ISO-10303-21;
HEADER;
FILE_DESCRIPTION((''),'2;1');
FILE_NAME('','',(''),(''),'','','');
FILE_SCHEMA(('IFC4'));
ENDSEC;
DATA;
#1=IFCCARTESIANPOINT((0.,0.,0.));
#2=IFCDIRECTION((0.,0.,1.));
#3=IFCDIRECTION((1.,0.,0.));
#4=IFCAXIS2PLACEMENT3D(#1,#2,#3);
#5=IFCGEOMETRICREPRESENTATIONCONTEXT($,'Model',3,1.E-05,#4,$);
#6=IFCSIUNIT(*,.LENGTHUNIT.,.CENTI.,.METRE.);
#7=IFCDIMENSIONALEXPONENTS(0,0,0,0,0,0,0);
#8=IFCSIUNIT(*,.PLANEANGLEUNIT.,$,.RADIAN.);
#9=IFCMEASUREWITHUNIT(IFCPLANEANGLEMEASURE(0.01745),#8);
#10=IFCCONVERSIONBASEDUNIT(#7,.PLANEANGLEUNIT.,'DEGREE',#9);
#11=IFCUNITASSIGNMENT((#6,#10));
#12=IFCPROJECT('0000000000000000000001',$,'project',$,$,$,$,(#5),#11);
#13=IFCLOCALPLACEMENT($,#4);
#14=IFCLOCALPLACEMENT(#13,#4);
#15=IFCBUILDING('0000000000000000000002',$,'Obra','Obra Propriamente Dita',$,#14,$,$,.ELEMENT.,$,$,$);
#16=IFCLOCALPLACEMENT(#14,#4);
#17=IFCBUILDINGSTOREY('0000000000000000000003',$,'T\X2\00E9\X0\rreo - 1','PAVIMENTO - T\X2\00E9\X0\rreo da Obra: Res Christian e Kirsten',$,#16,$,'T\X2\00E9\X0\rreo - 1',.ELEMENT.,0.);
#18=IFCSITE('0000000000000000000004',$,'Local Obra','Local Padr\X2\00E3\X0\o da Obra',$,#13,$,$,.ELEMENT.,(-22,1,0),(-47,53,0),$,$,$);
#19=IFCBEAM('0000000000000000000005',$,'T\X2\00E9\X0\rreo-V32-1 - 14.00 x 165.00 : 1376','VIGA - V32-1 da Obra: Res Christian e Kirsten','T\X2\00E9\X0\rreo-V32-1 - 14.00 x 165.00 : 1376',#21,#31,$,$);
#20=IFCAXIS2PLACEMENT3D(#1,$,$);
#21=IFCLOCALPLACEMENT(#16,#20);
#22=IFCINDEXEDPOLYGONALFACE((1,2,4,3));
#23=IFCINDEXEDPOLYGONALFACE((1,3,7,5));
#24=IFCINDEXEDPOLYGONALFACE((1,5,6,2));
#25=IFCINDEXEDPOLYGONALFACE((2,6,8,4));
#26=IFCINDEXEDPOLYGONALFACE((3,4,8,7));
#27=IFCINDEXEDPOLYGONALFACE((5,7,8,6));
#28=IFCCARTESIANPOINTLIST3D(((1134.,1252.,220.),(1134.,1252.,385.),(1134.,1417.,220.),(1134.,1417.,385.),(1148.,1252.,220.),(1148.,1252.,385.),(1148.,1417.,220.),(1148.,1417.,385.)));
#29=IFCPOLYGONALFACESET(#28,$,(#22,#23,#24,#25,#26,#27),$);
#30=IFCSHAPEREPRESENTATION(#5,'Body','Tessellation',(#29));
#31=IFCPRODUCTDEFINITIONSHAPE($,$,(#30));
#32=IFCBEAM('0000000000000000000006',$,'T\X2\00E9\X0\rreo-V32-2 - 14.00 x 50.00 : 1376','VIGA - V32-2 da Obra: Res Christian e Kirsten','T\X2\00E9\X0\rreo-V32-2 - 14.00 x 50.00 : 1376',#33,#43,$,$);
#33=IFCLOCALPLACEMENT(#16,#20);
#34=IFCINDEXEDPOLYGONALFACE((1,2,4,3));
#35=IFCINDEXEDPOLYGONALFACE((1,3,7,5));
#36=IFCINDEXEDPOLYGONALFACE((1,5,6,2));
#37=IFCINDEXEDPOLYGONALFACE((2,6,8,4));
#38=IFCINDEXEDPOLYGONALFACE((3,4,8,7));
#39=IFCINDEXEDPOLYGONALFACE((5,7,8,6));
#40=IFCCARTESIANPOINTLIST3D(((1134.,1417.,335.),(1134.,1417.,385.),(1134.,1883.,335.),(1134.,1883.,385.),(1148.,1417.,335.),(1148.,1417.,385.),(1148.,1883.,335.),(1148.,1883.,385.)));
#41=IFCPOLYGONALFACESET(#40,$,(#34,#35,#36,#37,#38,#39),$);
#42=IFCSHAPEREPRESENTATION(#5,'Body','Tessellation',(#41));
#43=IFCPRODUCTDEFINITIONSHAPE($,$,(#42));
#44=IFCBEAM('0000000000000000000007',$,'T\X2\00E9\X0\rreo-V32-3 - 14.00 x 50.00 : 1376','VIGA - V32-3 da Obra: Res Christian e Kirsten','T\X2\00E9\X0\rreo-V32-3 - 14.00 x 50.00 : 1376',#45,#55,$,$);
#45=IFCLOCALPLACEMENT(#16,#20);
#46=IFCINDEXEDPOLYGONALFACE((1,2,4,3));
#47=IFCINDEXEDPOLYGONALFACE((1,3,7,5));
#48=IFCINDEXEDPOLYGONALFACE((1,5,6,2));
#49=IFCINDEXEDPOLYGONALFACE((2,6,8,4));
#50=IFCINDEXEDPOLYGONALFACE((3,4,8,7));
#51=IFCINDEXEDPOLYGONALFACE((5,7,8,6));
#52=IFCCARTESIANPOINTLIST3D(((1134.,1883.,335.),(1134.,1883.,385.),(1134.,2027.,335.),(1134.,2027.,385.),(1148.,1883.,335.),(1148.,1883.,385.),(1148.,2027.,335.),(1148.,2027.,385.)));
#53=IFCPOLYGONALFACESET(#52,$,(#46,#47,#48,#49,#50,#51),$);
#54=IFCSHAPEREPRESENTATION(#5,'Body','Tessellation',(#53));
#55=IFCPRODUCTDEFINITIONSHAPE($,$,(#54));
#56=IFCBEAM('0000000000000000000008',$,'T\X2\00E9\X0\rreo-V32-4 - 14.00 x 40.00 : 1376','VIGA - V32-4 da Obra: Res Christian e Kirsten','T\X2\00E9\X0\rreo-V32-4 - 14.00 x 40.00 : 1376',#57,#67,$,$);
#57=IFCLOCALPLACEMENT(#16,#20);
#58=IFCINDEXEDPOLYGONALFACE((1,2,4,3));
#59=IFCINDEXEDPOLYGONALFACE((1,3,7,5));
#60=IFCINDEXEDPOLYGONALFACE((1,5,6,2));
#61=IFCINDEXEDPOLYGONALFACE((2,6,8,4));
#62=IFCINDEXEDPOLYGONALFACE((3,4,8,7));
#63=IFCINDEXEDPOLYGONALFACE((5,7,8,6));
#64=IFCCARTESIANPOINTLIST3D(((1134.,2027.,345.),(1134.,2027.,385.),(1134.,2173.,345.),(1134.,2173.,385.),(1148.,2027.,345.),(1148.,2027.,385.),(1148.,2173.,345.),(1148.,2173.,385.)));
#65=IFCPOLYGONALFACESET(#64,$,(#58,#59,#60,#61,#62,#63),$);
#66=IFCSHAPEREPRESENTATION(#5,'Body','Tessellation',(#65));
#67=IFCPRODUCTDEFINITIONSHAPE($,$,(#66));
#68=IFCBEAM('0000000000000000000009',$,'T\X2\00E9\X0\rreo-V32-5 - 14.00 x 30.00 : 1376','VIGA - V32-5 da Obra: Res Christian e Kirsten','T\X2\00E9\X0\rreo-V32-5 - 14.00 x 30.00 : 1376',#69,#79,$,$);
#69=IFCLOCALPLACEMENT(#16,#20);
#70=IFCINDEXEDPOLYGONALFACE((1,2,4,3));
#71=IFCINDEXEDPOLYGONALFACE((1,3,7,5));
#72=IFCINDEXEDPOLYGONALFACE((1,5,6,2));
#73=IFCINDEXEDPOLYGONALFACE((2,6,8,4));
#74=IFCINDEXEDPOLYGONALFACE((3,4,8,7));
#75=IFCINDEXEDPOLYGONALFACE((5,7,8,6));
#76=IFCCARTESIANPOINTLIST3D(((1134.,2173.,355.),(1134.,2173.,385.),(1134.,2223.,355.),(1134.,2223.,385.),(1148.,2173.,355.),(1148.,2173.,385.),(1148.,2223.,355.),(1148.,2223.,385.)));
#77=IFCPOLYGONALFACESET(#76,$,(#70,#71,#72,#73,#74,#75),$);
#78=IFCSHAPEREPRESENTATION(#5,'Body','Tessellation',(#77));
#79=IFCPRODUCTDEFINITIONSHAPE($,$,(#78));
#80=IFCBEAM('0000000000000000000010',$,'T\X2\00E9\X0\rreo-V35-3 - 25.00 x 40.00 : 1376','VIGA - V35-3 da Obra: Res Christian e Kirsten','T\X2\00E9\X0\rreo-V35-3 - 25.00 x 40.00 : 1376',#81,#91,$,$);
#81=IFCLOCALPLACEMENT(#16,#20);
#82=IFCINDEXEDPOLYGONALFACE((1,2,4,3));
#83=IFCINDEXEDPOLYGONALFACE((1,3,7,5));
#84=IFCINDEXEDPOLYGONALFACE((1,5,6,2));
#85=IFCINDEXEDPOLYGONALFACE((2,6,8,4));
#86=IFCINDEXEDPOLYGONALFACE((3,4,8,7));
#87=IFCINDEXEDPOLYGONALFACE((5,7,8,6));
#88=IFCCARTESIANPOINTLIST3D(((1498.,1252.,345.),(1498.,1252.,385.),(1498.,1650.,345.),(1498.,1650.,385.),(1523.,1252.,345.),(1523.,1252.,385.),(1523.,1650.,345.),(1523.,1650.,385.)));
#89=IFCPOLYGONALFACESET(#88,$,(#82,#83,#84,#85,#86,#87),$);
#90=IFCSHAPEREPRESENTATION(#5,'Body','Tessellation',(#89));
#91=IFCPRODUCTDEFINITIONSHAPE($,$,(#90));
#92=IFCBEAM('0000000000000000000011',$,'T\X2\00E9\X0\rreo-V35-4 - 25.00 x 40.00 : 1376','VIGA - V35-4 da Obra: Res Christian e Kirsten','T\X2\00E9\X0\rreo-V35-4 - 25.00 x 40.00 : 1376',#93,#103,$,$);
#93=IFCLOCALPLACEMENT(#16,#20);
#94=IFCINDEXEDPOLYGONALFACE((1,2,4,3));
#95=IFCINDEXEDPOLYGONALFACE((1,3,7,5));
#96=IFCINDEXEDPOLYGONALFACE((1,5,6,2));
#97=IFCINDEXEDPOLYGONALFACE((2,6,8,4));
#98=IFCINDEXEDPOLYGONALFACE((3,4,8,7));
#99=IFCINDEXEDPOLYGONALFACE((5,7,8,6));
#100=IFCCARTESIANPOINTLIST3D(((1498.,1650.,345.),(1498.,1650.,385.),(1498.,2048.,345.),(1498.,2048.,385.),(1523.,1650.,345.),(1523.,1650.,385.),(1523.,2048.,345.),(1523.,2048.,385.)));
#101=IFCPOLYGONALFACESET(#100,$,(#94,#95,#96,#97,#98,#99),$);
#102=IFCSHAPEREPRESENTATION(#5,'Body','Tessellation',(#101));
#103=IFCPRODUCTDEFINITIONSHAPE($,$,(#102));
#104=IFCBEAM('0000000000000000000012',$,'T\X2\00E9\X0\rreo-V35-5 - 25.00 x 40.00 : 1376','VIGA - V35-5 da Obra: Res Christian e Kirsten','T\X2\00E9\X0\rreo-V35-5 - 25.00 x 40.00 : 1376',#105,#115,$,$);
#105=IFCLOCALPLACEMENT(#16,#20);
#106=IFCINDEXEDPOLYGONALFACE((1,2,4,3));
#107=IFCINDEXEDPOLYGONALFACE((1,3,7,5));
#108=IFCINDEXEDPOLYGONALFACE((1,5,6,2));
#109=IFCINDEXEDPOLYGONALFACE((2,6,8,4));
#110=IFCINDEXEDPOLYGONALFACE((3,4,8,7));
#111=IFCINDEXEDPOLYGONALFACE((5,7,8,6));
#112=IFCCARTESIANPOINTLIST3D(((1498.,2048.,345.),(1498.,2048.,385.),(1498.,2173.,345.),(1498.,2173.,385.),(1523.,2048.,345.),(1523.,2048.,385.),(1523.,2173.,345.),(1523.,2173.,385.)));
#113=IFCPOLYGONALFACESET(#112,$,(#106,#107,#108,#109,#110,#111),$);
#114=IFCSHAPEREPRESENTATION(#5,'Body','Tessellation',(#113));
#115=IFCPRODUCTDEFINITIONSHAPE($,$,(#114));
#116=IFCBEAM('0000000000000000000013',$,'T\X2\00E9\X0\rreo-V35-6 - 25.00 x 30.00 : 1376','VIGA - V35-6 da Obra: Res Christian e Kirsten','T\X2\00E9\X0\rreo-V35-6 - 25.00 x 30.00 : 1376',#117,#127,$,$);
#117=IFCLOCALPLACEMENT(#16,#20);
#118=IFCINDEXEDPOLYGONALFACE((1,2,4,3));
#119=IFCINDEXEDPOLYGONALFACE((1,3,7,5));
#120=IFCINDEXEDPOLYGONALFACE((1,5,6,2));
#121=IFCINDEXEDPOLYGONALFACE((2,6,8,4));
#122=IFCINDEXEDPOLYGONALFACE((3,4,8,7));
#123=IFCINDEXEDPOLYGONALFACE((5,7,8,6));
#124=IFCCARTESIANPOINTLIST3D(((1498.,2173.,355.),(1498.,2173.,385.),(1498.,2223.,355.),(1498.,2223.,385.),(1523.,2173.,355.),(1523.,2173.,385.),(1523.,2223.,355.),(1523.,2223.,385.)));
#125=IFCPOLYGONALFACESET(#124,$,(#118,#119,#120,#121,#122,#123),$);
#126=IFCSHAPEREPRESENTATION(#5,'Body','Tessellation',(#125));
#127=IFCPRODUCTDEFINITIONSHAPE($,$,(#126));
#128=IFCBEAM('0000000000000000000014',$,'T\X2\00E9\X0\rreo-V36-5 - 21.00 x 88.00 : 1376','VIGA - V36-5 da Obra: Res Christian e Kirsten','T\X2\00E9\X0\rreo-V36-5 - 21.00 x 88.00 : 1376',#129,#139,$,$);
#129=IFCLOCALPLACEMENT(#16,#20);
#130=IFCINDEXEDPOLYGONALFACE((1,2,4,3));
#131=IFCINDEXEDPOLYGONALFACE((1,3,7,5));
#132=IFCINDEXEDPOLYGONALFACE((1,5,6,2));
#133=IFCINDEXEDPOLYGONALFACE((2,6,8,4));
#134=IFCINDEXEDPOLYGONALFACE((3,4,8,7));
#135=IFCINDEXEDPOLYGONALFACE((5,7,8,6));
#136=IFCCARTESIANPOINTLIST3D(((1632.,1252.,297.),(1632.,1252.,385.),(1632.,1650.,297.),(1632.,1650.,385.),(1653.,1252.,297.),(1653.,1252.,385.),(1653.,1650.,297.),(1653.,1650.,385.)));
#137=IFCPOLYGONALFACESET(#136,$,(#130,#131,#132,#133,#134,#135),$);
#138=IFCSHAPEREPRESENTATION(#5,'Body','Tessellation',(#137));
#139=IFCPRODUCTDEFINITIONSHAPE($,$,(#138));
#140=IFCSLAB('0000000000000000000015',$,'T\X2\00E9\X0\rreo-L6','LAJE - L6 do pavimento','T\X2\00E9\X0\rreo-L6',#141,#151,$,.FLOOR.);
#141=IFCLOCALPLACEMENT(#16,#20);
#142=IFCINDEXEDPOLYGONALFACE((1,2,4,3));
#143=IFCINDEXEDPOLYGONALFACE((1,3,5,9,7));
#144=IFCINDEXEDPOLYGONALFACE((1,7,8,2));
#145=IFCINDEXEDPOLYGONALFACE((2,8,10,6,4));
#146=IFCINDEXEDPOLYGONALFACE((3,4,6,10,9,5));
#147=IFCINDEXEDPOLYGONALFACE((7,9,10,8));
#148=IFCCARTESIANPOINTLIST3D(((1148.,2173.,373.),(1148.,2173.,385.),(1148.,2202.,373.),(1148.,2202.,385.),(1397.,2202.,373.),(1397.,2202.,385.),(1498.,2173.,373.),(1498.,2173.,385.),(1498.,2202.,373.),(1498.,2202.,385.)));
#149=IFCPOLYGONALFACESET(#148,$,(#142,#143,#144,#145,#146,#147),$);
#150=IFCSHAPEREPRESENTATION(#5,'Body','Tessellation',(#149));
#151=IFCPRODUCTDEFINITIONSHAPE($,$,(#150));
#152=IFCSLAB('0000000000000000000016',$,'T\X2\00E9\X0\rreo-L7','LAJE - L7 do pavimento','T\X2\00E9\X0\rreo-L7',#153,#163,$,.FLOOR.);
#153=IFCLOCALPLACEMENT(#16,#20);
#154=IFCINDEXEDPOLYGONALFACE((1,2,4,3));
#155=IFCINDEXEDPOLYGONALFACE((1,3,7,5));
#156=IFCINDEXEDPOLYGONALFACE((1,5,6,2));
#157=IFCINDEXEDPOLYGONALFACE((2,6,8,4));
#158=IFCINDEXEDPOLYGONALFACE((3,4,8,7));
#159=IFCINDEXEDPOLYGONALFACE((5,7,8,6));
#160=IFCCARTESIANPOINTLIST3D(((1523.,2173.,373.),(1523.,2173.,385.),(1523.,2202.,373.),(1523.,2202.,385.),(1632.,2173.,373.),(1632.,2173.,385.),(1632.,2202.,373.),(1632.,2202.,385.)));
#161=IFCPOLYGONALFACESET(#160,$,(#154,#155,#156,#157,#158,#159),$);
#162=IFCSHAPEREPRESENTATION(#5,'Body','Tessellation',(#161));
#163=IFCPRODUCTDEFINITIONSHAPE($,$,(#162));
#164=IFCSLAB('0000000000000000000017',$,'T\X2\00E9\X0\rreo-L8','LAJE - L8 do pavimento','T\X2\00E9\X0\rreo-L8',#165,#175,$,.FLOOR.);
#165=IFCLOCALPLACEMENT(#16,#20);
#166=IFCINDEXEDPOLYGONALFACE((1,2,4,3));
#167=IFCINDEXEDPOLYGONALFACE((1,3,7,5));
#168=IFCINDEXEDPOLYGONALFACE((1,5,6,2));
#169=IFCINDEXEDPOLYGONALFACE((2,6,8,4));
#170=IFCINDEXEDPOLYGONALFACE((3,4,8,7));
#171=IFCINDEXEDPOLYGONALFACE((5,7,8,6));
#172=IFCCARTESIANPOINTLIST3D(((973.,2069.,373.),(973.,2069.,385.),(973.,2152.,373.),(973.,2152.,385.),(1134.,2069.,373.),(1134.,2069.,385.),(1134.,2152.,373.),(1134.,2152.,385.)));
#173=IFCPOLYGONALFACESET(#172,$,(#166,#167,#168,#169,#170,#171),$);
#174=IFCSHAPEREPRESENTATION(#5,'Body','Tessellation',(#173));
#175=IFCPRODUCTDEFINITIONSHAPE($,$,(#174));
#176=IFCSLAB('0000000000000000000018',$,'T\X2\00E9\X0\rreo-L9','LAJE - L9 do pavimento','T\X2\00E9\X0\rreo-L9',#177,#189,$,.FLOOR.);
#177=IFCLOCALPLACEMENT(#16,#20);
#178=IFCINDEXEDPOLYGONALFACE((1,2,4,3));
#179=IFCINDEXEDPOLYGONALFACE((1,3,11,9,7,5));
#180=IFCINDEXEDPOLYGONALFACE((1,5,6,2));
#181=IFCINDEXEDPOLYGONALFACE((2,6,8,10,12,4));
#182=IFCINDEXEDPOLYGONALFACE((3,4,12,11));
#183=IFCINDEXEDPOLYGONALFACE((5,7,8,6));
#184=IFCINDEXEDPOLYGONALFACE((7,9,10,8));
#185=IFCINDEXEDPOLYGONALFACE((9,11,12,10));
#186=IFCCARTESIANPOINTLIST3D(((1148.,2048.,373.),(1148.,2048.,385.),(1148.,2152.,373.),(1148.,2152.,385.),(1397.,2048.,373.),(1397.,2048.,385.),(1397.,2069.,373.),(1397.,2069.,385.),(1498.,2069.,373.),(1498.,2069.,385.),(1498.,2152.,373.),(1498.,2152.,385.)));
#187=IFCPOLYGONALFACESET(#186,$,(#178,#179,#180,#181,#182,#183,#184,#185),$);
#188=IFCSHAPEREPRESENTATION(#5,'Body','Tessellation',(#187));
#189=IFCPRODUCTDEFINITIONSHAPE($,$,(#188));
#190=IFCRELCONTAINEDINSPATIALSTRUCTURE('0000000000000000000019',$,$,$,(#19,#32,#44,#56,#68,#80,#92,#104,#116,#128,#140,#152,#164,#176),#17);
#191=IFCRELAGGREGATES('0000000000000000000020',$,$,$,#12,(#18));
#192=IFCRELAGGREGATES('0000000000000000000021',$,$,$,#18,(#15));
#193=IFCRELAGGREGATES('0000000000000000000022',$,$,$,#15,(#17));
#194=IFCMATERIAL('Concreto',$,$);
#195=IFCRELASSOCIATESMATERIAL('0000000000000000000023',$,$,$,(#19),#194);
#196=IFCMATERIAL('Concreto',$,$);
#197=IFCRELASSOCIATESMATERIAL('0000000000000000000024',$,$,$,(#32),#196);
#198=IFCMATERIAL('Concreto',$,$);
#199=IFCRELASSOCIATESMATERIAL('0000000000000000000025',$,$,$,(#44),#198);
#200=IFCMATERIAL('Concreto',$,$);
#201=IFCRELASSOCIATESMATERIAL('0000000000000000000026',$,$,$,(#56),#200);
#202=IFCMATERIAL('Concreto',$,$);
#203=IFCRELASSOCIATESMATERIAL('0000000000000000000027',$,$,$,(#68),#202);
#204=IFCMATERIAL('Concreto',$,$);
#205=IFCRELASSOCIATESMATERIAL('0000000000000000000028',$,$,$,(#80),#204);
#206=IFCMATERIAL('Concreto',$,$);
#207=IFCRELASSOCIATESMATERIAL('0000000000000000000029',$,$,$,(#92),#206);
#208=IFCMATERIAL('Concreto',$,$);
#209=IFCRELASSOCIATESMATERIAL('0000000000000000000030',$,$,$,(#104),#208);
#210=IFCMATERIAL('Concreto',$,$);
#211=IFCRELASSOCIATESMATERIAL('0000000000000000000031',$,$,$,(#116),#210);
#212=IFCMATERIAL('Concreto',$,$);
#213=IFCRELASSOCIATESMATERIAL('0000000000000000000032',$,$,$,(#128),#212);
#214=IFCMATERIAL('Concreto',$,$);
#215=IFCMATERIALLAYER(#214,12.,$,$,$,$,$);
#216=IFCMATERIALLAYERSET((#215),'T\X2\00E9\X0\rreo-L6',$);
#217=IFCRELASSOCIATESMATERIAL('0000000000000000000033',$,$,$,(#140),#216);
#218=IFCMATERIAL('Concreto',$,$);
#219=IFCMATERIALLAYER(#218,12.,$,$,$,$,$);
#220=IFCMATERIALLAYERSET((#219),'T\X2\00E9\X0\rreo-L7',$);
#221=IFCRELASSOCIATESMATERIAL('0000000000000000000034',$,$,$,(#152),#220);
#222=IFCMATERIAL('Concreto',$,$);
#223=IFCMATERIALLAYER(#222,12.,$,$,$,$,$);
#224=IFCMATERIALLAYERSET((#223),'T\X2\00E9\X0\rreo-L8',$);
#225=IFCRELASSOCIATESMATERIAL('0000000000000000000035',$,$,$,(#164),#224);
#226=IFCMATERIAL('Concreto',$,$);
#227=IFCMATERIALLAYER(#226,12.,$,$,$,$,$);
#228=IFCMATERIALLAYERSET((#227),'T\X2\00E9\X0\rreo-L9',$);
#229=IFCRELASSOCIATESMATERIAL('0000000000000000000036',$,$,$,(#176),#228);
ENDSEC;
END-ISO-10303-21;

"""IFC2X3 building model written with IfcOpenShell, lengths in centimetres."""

from ifc_helpers import new_model, entity, si_unit, converted_unit, frame, origin_with_axes, place, context, project, spatial, polyline, outline, extrude, material, layer, layer_set, layer_usage, element, save


model = new_model("IFC2X3")

# Units and contexts
model_context = context("Model", 3, precision=1e-05, world=origin_with_axes())
ifc_project = project(units=[si_unit("LENGTHUNIT", "METRE", prefix="CENTI"), converted_unit("PLANEANGLEUNIT", "DEGREE", entity("IfcPlaneAngleMeasure", 0.01745), si_unit("PLANEANGLEUNIT", "RADIAN"), dimensions=[0, 0, 0, 0, 0, 0, 0])], contexts=[model_context])

# Site, building, storey
site_placement = place(None, origin_with_axes())
site = spatial("IfcSite", under=ifc_project, at=site_placement, Name="Local Obra", Description="Local Padrão da Obra", CompositionType="ELEMENT", RefLatitude=(-22, 1, 0), RefLongitude=(-47, 53, 0))
building_placement = place(site_placement, origin_with_axes())
building = spatial("IfcBuilding", under=site, at=building_placement, Name="Obra", Description="Obra Propriamente Dita", CompositionType="ELEMENT")
storey_placement = place(building_placement, origin_with_axes())
storey = spatial("IfcBuildingStorey", under=building, at=storey_placement, Name="Térreo - 1", Description="PAVIMENTO - Térreo da Obra: Res Christian e Kirsten", LongName="Térreo - 1", CompositionType="ELEMENT", Elevation=0.0)

# Beams
ifc_material_1 = material(Name="Concreto")
beam_1_placement = place(storey_placement, frame((1148.0, 1252.0, 385.0), z_axis=(0.0, 1.0, 0.0), x_axis=(1.0, 0.0, 0.0)))
element("IfcBeam", 1, at=beam_1_placement, inside=storey, material=ifc_material_1, Name="Térreo-V32-1 - 14.00 x 165.00 : 1376", Description="VIGA - V32-1 da Obra: Res Christian e Kirsten", ObjectType="Térreo-V32-1 - 14.00 x 165.00 : 1376", context=model_context, shape_type="SweptSolid", body=[
    extrude(outline(polyline([(-14.0, 0.0), (0.0, 0.0), (0.0, 165.0), (-14.0, 165.0), (-14.0, 0.0)])), origin_with_axes(), (0.0, 0.0, 1.0), 165.0),
])
ifc_material_2 = material(Name="Concreto")
beam_2_placement = place(storey_placement, frame((1148.0, 1417.0, 385.0), z_axis=(0.0, 1.0, 0.0), x_axis=(1.0, 0.0, 0.0)))
element("IfcBeam", 2, at=beam_2_placement, inside=storey, material=ifc_material_2, Name="Térreo-V32-2 - 14.00 x 50.00 : 1376", Description="VIGA - V32-2 da Obra: Res Christian e Kirsten", ObjectType="Térreo-V32-2 - 14.00 x 50.00 : 1376", context=model_context, shape_type="SweptSolid", body=[
    extrude(outline(polyline([(-14.0, 0.0), (0.0, 0.0), (0.0, 50.0), (-14.0, 50.0), (-14.0, 0.0)])), origin_with_axes(), (0.0, 0.0, 1.0), 466.0),
])
ifc_material_3 = material(Name="Concreto")
beam_3_placement = place(storey_placement, frame((1148.0, 1883.0, 385.0), z_axis=(0.0, 1.0, 0.0), x_axis=(1.0, 0.0, 0.0)))
element("IfcBeam", 3, at=beam_3_placement, inside=storey, material=ifc_material_3, Name="Térreo-V32-3 - 14.00 x 50.00 : 1376", Description="VIGA - V32-3 da Obra: Res Christian e Kirsten", ObjectType="Térreo-V32-3 - 14.00 x 50.00 : 1376", context=model_context, shape_type="SweptSolid", body=[
    extrude(outline(polyline([(-14.0, 0.0), (0.0, 0.0), (0.0, 50.0), (-14.0, 50.0), (-14.0, 0.0)])), origin_with_axes(), (0.0, 0.0, 1.0), 144.0),
])
ifc_material_4 = material(Name="Concreto")
beam_4_placement = place(storey_placement, frame((1148.0, 2027.0, 385.0), z_axis=(0.0, 1.0, 0.0), x_axis=(1.0, 0.0, 0.0)))
element("IfcBeam", 4, at=beam_4_placement, inside=storey, material=ifc_material_4, Name="Térreo-V32-4 - 14.00 x 40.00 : 1376", Description="VIGA - V32-4 da Obra: Res Christian e Kirsten", ObjectType="Térreo-V32-4 - 14.00 x 40.00 : 1376", context=model_context, shape_type="SweptSolid", body=[
    extrude(outline(polyline([(-14.0, 0.0), (0.0, 0.0), (0.0, 40.0), (-14.0, 40.0), (-14.0, 0.0)])), origin_with_axes(), (0.0, 0.0, 1.0), 146.0),
])
ifc_material_5 = material(Name="Concreto")
beam_5_placement = place(storey_placement, frame((1148.0, 2173.0, 385.0), z_axis=(0.0, 1.0, 0.0), x_axis=(1.0, 0.0, 0.0)))
element("IfcBeam", 5, at=beam_5_placement, inside=storey, material=ifc_material_5, Name="Térreo-V32-5 - 14.00 x 30.00 : 1376", Description="VIGA - V32-5 da Obra: Res Christian e Kirsten", ObjectType="Térreo-V32-5 - 14.00 x 30.00 : 1376", context=model_context, shape_type="SweptSolid", body=[
    extrude(outline(polyline([(-14.0, 0.0), (0.0, 0.0), (0.0, 30.0), (-14.0, 30.0), (-14.0, 0.0)])), origin_with_axes(), (0.0, 0.0, 1.0), 50.0),
])
ifc_material_6 = material(Name="Concreto")
beam_6_placement = place(storey_placement, frame((1523.0, 1252.0, 385.0), z_axis=(0.0, 1.0, 0.0), x_axis=(1.0, 0.0, 0.0)))
element("IfcBeam", 6, at=beam_6_placement, inside=storey, material=ifc_material_6, Name="Térreo-V35-3 - 25.00 x 40.00 : 1376", Description="VIGA - V35-3 da Obra: Res Christian e Kirsten", ObjectType="Térreo-V35-3 - 25.00 x 40.00 : 1376", context=model_context, shape_type="SweptSolid", body=[
    extrude(outline(polyline([(-25.0, 0.0), (0.0, 0.0), (0.0, 40.0), (-25.0, 40.0), (-25.0, 0.0)])), origin_with_axes(), (0.0, 0.0, 1.0), 398.0),
])
ifc_material_7 = material(Name="Concreto")
beam_7_placement = place(storey_placement, frame((1523.0, 1650.0, 385.0), z_axis=(0.0, 1.0, 0.0), x_axis=(1.0, 0.0, 0.0)))
element("IfcBeam", 7, at=beam_7_placement, inside=storey, material=ifc_material_7, Name="Térreo-V35-4 - 25.00 x 40.00 : 1376", Description="VIGA - V35-4 da Obra: Res Christian e Kirsten", ObjectType="Térreo-V35-4 - 25.00 x 40.00 : 1376", context=model_context, shape_type="SweptSolid", body=[
    extrude(outline(polyline([(-25.0, 0.0), (0.0, 0.0), (0.0, 40.0), (-25.0, 40.0), (-25.0, 0.0)])), origin_with_axes(), (0.0, 0.0, 1.0), 398.0),
])
ifc_material_8 = material(Name="Concreto")
beam_8_placement = place(storey_placement, frame((1523.0, 2048.0, 385.0), z_axis=(0.0, 1.0, 0.0), x_axis=(1.0, 0.0, 0.0)))
element("IfcBeam", 8, at=beam_8_placement, inside=storey, material=ifc_material_8, Name="Térreo-V35-5 - 25.00 x 40.00 : 1376", Description="VIGA - V35-5 da Obra: Res Christian e Kirsten", ObjectType="Térreo-V35-5 - 25.00 x 40.00 : 1376", context=model_context, shape_type="SweptSolid", body=[
    extrude(outline(polyline([(-25.0, 0.0), (0.0, 0.0), (0.0, 40.0), (-25.0, 40.0), (-25.0, 0.0)])), origin_with_axes(), (0.0, 0.0, 1.0), 125.0),
])
ifc_material_9 = material(Name="Concreto")
beam_9_placement = place(storey_placement, frame((1523.0, 2173.0, 385.0), z_axis=(0.0, 1.0, 0.0), x_axis=(1.0, 0.0, 0.0)))
element("IfcBeam", 9, at=beam_9_placement, inside=storey, material=ifc_material_9, Name="Térreo-V35-6 - 25.00 x 30.00 : 1376", Description="VIGA - V35-6 da Obra: Res Christian e Kirsten", ObjectType="Térreo-V35-6 - 25.00 x 30.00 : 1376", context=model_context, shape_type="SweptSolid", body=[
    extrude(outline(polyline([(-25.0, 0.0), (0.0, 0.0), (0.0, 30.0), (-25.0, 30.0), (-25.0, 0.0)])), origin_with_axes(), (0.0, 0.0, 1.0), 50.0),
])
ifc_material_10 = material(Name="Concreto")
beam_10_placement = place(storey_placement, frame((1653.0, 1252.0, 385.0), z_axis=(0.0, 1.0, 0.0), x_axis=(1.0, 0.0, 0.0)))
element("IfcBeam", 10, at=beam_10_placement, inside=storey, material=ifc_material_10, Name="Térreo-V36-5 - 21.00 x 88.00 : 1376", Description="VIGA - V36-5 da Obra: Res Christian e Kirsten", ObjectType="Térreo-V36-5 - 21.00 x 88.00 : 1376", context=model_context, shape_type="SweptSolid", body=[
    extrude(outline(polyline([(-21.0, 0.0), (0.0, 0.0), (0.0, 88.0), (-21.0, 88.0), (-21.0, 0.0)])), origin_with_axes(), (0.0, 0.0, 1.0), 398.0),
])

# Slabs
ifc_material_11 = material(Name="Concreto")
ifc_layer_1 = layer(ifc_material_11, 12.0)
ifc_layer_set_1 = layer_set([ifc_layer_1], Name="Térreo-L6")
ifc_layer_usage_1 = layer_usage(ifc_layer_set_1, "AXIS3", "POSITIVE", 0.0)
slab_1_placement = place(storey_placement, frame((1148.0, 2173.0, 373.0), z_axis=(0.0, 0.0, 1.0), x_axis=(1.0, 0.0, 0.0)))
element("IfcSlab", 11, at=slab_1_placement, inside=storey, material=ifc_layer_usage_1, Name="Térreo-L6", Description="LAJE - L6 do pavimento", ObjectType="Térreo-L6", PredefinedType="FLOOR", context=model_context, shape_type="SweptSolid", body=[
    extrude(outline(polyline([(350.0, 0.0), (350.0, 29.0), (249.0, 29.0), (0.0, 29.0), (0.0, 0.0), (350.0, 0.0)])), origin_with_axes(), (0.0, 0.0, 1.0), 12.0),
])
ifc_material_12 = material(Name="Concreto")
ifc_layer_2 = layer(ifc_material_12, 12.0)
ifc_layer_set_2 = layer_set([ifc_layer_2], Name="Térreo-L7")
ifc_layer_usage_2 = layer_usage(ifc_layer_set_2, "AXIS3", "POSITIVE", 0.0)
slab_2_placement = place(storey_placement, frame((1523.0, 2173.0, 373.0), z_axis=(0.0, 0.0, 1.0), x_axis=(1.0, 0.0, 0.0)))
element("IfcSlab", 12, at=slab_2_placement, inside=storey, material=ifc_layer_usage_2, Name="Térreo-L7", Description="LAJE - L7 do pavimento", ObjectType="Térreo-L7", PredefinedType="FLOOR", context=model_context, shape_type="SweptSolid", body=[
    extrude(outline(polyline([(109.0, 0.0), (109.0, 29.0), (0.0, 29.0), (0.0, 0.0), (109.0, 0.0)])), origin_with_axes(), (0.0, 0.0, 1.0), 12.0),
])
ifc_material_13 = material(Name="Concreto")
ifc_layer_3 = layer(ifc_material_13, 12.0)
ifc_layer_set_3 = layer_set([ifc_layer_3], Name="Térreo-L8")
ifc_layer_usage_3 = layer_usage(ifc_layer_set_3, "AXIS3", "POSITIVE", 0.0)
slab_3_placement = place(storey_placement, frame((1134.0, 2069.0, 373.0), z_axis=(0.0, 0.0, 1.0), x_axis=(1.0, 0.0, 0.0)))
element("IfcSlab", 13, at=slab_3_placement, inside=storey, material=ifc_layer_usage_3, Name="Térreo-L8", Description="LAJE - L8 do pavimento", ObjectType="Térreo-L8", PredefinedType="FLOOR", context=model_context, shape_type="SweptSolid", body=[
    extrude(outline(polyline([(0.0, 83.0), (-161.0, 83.0), (-161.0, 0.0), (0.0, 0.0), (0.0, 83.0)])), origin_with_axes(), (0.0, 0.0, 1.0), 12.0),
])
ifc_material_14 = material(Name="Concreto")
ifc_layer_4 = layer(ifc_material_14, 12.0)
ifc_layer_set_4 = layer_set([ifc_layer_4], Name="Térreo-L9")
ifc_layer_usage_4 = layer_usage(ifc_layer_set_4, "AXIS3", "POSITIVE", 0.0)
slab_4_placement = place(storey_placement, frame((1498.0, 2069.0, 373.0), z_axis=(0.0, 0.0, 1.0), x_axis=(1.0, 0.0, 0.0)))
element("IfcSlab", 14, at=slab_4_placement, inside=storey, material=ifc_layer_usage_4, Name="Térreo-L9", Description="LAJE - L9 do pavimento", ObjectType="Térreo-L9", PredefinedType="FLOOR", context=model_context, shape_type="SweptSolid", body=[
    extrude(outline(polyline([(0.0, 83.0), (-350.0, 83.0), (-350.0, -21.0), (-101.0, -21.0), (-101.0, 0.0), (0.0, 0.0), (0.0, 83.0)])), origin_with_axes(), (0.0, 0.0, 1.0), 12.0),
])

save(model, "model.ifc")
